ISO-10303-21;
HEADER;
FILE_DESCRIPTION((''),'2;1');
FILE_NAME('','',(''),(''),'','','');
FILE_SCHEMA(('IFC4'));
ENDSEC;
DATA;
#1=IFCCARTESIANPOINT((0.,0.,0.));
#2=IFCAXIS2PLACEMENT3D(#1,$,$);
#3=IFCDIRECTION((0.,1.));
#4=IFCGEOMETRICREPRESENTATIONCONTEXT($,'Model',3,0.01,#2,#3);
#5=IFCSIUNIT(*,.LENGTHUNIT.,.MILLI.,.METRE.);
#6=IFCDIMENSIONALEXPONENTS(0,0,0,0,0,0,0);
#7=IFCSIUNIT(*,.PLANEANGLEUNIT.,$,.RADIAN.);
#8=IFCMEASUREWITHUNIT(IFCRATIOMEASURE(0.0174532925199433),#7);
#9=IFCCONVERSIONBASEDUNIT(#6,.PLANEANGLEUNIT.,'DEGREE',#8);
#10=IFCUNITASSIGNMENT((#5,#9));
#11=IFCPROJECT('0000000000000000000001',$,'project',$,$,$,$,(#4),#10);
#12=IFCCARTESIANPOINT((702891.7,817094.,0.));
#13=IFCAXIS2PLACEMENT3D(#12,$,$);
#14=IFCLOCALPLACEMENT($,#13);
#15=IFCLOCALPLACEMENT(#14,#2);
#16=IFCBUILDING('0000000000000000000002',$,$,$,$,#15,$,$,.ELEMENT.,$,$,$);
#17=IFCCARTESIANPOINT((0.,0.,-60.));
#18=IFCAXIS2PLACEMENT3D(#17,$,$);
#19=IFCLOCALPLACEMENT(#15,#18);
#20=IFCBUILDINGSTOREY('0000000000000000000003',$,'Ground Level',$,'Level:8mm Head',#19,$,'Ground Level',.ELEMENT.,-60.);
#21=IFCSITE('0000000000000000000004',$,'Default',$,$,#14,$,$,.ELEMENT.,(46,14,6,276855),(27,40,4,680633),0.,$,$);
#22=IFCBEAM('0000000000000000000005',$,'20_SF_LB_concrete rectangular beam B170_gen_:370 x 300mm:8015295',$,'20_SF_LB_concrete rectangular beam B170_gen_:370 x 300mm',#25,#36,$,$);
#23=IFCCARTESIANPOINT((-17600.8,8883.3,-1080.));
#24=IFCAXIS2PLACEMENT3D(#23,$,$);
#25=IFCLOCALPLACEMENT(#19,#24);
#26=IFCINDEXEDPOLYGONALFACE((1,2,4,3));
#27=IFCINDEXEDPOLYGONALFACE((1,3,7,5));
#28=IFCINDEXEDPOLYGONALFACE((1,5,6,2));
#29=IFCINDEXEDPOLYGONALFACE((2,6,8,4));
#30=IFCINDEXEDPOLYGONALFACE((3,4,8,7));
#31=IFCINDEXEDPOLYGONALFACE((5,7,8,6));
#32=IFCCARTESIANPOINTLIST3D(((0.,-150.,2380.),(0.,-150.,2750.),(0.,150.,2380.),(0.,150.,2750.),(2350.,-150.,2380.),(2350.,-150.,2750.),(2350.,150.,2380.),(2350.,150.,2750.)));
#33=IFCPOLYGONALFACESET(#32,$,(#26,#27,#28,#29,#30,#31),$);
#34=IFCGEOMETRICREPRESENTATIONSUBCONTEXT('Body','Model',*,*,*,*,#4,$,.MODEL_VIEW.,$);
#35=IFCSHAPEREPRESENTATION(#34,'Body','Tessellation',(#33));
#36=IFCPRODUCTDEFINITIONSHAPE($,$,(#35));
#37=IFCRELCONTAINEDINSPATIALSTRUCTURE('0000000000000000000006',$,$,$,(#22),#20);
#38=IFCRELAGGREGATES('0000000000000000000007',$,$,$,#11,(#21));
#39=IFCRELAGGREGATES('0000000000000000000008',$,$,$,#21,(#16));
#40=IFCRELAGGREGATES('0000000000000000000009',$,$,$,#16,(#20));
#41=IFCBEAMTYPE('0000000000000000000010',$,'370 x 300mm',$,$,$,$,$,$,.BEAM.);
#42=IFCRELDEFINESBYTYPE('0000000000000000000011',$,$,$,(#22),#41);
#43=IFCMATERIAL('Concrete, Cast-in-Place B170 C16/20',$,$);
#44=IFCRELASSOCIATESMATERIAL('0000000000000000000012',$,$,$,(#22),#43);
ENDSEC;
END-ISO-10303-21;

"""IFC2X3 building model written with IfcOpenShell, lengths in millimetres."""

from ifc_helpers import new_model, entity, si_unit, converted_unit, direction, frame, frame_2d, origin, place, context, subcontext, project, spatial, rectangle, extrude, material, type_object, element, save


model = new_model("IFC2X3")

# Units and contexts
model_context = context("Model", 3, precision=0.01, world=origin(), true_north=direction((0.0, 1.0)))
body_context = subcontext(model_context, "Body", "Model", "MODEL_VIEW")
ifc_project = project(units=[si_unit("LENGTHUNIT", "METRE", prefix="MILLI"), converted_unit("PLANEANGLEUNIT", "DEGREE", entity("IfcRatioMeasure", 0.0174532925199433), si_unit("PLANEANGLEUNIT", "RADIAN"), dimensions=[0, 0, 0, 0, 0, 0, 0])], contexts=[model_context])

# Site, building, storey
site_placement = place(None, frame((702891.7, 817094.0, 0.0)))
site = spatial("IfcSite", under=ifc_project, at=site_placement, Name="Default", CompositionType="ELEMENT", RefLatitude=(46, 14, 6, 276855), RefLongitude=(27, 40, 4, 680633), RefElevation=0.0)
building_placement = place(site_placement, origin())
building = spatial("IfcBuilding", under=site, at=building_placement, CompositionType="ELEMENT")
storey_placement = place(building_placement, frame((0.0, 0.0, -60.0)))
storey = spatial("IfcBuildingStorey", under=building, at=storey_placement, Name="Ground Level", ObjectType="Level:8mm Head", LongName="Ground Level", CompositionType="ELEMENT", Elevation=-60.0)

# Beam
ifc_material_1 = material(Name="Concrete, Cast-in-Place B170 C16/20")
beam_type_1 = type_object("IfcBeamType", Name="370 x 300mm", PredefinedType="BEAM")
beam_1_placement = place(storey_placement, frame((-17600.8, 8883.3, -1080.0)))
element("IfcBeam", 1, at=beam_1_placement, inside=storey, type_object=beam_type_1, material=ifc_material_1, Name="20_SF_LB_concrete rectangular beam B170_gen_:370 x 300mm:8015295", ObjectType="20_SF_LB_concrete rectangular beam B170_gen_:370 x 300mm", context=body_context, shape_type="SweptSolid", body=[
    extrude(rectangle(XDim=370.0, YDim=300.0, at=frame_2d((0.0, 0.0), x_axis=(1.0, 0.0))), frame((0.0, 0.0, 2565.0), z_axis=(1.0, 0.0, 0.0), x_axis=(0.0, 0.0, -1.0)), (0.0, 0.0, 1.0), 2350.0),
])

save(model, "model.ifc")
